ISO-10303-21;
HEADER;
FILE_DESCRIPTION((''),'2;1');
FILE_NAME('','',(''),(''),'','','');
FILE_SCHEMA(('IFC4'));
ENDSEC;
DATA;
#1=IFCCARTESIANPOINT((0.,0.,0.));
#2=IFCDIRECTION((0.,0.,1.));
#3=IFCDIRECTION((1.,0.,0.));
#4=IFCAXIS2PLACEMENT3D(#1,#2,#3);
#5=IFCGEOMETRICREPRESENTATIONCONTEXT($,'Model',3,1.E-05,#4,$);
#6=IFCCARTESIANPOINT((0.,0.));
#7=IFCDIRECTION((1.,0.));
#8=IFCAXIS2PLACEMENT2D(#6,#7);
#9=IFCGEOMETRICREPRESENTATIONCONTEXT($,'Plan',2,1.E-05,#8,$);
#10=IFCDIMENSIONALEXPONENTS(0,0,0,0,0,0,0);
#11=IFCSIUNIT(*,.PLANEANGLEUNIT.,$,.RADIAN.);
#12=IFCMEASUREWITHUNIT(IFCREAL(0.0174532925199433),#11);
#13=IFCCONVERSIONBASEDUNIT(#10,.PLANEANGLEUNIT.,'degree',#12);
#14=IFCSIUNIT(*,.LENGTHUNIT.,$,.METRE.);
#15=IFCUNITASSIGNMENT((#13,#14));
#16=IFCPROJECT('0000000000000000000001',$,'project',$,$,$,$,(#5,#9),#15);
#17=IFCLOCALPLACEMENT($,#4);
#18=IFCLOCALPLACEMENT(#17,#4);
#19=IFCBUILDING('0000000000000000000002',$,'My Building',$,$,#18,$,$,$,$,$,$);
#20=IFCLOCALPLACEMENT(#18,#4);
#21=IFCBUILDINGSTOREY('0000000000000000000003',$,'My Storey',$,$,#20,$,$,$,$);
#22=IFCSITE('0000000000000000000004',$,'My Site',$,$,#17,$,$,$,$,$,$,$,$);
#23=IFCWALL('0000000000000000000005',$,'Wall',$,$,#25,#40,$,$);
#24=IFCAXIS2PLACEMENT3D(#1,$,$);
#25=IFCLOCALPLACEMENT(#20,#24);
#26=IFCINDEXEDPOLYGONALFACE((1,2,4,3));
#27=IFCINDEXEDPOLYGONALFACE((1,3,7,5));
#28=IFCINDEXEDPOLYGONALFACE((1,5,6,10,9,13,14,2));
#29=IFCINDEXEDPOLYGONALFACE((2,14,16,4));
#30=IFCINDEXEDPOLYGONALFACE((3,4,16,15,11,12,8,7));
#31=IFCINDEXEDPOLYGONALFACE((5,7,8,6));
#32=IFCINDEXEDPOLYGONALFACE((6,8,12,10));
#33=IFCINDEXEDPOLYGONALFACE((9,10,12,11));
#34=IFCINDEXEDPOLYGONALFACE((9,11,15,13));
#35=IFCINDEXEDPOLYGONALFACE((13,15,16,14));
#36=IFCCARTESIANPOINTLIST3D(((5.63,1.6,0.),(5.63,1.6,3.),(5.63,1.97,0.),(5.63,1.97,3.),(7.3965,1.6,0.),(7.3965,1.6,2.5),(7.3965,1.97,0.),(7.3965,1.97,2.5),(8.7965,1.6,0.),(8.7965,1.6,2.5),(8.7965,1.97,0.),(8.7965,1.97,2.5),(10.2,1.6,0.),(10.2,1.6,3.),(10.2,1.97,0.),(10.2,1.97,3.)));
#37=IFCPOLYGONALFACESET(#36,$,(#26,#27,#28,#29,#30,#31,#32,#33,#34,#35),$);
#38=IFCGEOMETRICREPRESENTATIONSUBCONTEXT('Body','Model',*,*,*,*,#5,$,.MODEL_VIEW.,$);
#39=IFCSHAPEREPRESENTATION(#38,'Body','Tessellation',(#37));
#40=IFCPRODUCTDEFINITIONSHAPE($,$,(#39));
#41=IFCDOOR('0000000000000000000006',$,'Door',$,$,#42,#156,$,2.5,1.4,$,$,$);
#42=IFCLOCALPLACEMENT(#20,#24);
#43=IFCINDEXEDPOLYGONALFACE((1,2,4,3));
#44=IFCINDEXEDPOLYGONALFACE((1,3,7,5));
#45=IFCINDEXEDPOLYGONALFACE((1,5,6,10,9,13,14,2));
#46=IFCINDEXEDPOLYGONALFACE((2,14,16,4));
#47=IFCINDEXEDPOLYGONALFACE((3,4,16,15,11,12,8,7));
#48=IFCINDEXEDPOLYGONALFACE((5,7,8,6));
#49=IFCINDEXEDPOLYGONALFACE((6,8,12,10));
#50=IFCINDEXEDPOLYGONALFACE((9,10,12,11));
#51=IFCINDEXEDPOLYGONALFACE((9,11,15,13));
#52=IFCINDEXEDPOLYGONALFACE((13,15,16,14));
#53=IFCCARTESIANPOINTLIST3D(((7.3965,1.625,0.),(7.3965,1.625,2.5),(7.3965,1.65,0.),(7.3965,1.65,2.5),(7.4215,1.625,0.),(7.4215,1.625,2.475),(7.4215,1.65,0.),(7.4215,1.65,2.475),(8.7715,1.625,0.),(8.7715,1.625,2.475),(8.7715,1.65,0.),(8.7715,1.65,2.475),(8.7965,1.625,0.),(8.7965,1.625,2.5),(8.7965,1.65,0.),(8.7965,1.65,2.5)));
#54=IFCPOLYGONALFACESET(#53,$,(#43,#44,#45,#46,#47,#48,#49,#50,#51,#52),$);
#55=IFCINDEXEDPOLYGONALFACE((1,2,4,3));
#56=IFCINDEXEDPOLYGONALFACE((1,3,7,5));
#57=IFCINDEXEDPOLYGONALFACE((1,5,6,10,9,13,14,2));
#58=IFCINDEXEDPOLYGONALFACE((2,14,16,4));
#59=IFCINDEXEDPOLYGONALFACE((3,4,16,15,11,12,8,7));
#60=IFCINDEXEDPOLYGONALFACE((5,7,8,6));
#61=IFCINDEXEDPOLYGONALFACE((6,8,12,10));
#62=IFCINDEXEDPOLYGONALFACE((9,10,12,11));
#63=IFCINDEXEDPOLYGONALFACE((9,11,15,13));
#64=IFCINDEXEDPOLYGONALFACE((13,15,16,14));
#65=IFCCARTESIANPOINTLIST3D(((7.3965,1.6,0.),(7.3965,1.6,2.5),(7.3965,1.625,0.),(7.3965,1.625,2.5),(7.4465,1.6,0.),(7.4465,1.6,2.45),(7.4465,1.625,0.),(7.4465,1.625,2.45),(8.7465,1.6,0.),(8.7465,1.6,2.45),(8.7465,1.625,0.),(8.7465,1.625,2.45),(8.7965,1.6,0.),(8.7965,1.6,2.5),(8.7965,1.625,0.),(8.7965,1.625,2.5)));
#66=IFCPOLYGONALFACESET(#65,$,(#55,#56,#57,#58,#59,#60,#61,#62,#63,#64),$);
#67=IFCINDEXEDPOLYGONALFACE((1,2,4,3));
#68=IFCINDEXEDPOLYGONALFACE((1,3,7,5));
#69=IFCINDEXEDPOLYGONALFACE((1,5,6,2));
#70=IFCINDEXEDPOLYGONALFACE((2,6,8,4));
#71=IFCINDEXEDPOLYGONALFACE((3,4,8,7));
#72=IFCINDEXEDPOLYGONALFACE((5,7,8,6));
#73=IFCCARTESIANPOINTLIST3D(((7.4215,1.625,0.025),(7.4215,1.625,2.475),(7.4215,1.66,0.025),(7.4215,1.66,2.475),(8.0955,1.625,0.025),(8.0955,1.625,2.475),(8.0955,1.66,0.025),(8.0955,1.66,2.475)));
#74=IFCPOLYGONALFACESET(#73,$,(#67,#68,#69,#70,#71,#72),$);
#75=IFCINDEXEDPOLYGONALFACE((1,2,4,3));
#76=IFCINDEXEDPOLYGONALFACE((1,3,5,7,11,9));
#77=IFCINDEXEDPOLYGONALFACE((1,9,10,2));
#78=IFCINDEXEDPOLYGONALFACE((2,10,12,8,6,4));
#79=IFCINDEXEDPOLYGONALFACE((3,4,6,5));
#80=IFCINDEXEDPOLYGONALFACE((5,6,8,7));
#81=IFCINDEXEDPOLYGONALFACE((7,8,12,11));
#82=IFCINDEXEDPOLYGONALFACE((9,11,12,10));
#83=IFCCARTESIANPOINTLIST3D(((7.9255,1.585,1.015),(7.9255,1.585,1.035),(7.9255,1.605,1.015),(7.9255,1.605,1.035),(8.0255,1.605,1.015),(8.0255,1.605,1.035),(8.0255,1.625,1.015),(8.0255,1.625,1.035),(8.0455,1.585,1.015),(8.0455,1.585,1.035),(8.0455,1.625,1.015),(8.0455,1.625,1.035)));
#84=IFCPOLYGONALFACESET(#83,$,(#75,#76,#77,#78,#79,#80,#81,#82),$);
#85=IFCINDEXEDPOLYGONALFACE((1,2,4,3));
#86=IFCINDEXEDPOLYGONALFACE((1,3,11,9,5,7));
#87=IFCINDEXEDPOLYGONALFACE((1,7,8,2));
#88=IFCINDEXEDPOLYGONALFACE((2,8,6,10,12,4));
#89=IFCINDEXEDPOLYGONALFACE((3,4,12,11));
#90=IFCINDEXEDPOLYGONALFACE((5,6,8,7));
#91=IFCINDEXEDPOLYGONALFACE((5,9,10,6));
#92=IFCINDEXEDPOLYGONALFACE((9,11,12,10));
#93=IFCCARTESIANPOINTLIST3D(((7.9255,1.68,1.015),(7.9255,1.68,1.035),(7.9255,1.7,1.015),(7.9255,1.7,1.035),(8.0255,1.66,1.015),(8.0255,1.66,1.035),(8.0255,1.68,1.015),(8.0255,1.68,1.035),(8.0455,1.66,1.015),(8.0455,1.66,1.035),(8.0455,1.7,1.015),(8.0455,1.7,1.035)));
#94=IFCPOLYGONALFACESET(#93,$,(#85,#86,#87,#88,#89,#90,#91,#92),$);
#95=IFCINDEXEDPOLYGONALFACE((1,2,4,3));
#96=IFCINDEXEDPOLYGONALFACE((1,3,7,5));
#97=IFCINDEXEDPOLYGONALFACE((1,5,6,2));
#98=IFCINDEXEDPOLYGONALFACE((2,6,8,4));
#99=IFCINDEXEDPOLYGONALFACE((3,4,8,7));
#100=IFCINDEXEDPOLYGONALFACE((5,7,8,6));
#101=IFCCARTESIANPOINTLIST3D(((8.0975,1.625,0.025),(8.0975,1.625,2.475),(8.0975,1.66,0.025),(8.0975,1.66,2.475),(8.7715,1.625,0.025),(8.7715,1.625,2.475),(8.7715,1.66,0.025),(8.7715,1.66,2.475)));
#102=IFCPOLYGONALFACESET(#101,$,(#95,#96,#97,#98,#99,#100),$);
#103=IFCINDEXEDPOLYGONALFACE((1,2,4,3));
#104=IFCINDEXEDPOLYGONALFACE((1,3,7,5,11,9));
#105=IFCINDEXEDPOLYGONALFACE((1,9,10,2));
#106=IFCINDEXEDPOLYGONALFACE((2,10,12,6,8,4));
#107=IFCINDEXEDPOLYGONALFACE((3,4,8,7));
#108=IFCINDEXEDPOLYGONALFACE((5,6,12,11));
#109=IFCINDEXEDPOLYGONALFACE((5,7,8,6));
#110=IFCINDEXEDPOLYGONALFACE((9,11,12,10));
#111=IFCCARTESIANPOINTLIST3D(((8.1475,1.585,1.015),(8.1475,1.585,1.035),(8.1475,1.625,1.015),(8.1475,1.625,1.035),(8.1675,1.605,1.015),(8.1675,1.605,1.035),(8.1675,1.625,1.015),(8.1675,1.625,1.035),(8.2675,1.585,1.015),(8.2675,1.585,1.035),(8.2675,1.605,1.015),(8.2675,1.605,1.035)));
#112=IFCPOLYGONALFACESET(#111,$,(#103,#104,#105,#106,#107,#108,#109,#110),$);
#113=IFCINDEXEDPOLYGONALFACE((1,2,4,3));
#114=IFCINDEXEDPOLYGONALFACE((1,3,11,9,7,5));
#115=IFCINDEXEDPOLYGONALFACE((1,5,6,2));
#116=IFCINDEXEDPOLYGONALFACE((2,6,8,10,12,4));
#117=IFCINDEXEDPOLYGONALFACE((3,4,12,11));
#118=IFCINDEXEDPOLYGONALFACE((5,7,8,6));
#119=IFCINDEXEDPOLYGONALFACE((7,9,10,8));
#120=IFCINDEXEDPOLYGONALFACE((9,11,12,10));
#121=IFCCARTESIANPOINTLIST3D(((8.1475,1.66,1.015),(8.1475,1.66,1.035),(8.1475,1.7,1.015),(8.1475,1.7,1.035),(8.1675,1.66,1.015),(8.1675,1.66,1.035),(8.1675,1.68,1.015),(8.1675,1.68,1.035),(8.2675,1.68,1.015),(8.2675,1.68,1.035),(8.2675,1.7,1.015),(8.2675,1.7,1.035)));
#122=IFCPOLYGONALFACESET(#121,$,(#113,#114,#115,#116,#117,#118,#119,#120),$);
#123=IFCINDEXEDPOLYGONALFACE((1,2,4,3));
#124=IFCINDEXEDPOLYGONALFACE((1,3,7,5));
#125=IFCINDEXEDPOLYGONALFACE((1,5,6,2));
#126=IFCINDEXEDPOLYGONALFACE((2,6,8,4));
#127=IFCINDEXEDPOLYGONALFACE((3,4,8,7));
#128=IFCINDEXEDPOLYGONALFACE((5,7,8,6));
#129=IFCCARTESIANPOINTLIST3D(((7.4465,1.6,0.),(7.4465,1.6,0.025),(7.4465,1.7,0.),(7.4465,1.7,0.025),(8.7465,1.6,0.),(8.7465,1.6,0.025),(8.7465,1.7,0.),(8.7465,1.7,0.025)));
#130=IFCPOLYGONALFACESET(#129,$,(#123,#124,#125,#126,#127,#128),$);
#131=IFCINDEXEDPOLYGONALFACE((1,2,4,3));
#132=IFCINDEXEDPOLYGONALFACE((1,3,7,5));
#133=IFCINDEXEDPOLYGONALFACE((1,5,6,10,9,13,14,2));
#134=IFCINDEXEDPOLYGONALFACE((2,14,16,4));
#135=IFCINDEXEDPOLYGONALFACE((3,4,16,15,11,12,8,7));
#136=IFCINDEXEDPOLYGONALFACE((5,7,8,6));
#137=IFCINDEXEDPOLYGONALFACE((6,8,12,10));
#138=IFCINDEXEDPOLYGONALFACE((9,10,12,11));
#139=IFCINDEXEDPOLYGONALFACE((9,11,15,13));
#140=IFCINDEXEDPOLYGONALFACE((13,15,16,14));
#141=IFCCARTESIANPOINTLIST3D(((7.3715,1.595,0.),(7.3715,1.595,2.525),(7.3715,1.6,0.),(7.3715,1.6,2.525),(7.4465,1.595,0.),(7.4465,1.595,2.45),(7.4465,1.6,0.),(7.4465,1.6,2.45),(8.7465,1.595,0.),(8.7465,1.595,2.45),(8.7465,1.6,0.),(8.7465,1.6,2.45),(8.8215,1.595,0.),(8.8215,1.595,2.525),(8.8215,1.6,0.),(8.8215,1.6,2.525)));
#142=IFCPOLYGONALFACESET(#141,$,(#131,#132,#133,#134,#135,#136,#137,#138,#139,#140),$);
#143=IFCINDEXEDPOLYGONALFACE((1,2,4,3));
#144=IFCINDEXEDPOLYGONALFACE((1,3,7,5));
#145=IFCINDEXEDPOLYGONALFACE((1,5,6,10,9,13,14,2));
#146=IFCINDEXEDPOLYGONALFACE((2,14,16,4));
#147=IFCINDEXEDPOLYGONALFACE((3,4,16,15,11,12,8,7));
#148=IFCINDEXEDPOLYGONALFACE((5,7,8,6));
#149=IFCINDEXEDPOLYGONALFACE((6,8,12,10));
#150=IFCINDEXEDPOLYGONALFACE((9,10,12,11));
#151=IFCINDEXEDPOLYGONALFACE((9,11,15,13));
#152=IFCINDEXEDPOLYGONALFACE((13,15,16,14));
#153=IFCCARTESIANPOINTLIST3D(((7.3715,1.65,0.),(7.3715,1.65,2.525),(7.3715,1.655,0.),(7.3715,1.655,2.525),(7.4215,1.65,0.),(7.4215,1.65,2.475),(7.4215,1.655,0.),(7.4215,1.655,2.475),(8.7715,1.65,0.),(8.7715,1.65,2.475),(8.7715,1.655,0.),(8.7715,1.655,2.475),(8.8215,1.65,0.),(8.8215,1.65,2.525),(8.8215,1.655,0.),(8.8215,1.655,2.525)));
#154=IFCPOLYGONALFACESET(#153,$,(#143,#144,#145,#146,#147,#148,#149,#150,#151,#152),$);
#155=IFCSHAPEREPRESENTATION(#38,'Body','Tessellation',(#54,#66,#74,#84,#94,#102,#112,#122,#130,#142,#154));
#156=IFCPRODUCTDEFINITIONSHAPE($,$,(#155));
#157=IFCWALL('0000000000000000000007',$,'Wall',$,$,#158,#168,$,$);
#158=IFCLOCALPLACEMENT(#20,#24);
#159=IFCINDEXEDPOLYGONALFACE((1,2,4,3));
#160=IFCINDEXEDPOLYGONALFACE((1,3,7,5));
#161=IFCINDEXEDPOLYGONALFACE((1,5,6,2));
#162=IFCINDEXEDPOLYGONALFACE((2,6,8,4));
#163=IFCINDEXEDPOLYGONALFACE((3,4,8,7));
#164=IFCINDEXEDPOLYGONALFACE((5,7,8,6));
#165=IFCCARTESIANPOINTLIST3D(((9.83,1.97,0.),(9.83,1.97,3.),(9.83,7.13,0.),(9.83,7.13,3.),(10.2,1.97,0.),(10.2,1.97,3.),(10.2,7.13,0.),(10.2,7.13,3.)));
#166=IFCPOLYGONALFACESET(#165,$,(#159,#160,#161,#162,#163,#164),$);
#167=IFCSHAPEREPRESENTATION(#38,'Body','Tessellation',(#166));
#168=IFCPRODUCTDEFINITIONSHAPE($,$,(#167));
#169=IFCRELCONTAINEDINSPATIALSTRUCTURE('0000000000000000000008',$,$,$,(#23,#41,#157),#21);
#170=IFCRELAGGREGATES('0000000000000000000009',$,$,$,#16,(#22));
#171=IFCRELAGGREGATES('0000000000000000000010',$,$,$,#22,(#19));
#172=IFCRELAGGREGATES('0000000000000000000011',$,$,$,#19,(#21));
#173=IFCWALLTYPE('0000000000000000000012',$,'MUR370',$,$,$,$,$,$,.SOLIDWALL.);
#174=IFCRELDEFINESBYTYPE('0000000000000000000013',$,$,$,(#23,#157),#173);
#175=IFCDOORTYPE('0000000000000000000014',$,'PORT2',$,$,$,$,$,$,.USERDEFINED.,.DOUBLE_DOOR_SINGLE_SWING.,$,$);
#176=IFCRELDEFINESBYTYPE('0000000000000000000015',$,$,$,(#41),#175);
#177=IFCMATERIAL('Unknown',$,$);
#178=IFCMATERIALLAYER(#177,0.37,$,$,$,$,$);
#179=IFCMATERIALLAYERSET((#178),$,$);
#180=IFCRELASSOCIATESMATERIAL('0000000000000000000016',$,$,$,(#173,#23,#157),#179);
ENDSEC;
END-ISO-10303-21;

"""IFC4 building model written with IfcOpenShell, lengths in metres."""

from ifc_helpers import new_model, entity, si_unit, converted_unit, frame, origin_with_axes, origin_2d_with_axis, place, context, subcontext, project, spatial, line, indexed_curve, outline, extrude, shape, source, transform, mapped, material, layer, layer_set, layer_usage, type_object, type_shapes, element, fill, save


model = new_model("IFC4")

# Units and contexts
model_context = context("Model", 3, precision=1e-05, world=origin_with_axes())
plan_context = context("Plan", 2, precision=1e-05, world=origin_2d_with_axis())
body_context_1 = subcontext(model_context, "Body", "Model", "MODEL_VIEW")
body_context_2 = subcontext(plan_context, "Body", "Plan", "PLAN_VIEW")
ifc_project = project(units=[converted_unit("PLANEANGLEUNIT", "degree", entity("IfcReal", 0.0174532925199433), si_unit("PLANEANGLEUNIT", "RADIAN"), dimensions=[0, 0, 0, 0, 0, 0, 0]), si_unit("LENGTHUNIT", "METRE")], contexts=[model_context, plan_context])

# Site, building, storey
site_placement = place(None, origin_with_axes())
site = spatial("IfcSite", under=ifc_project, at=site_placement, Name="My Site")
building_placement = place(site_placement, origin_with_axes())
building = spatial("IfcBuilding", under=site, at=building_placement, Name="My Building")
storey_placement = place(building_placement, origin_with_axes())
storey = spatial("IfcBuildingStorey", under=building, at=storey_placement, Name="My Storey")

# Shared definitions
ifc_material = material(Name="Unknown")

# Shared definitions
ifc_layer_1 = layer(ifc_material, 0.37)
ifc_layer_set_1 = layer_set([ifc_layer_1])
wall_type_1 = type_object("IfcWallType", Name="MUR370", PredefinedType="SOLIDWALL", material=ifc_layer_set_1)

# Wall, opening, door
ifc_layer_usage_1 = layer_usage(ifc_layer_set_1, "AXIS2", "POSITIVE", 0.0)
wall_1_placement = place(storey_placement, frame((5.63, 1.6, 0.0), z_axis=(0.0, 0.0, 1.0), x_axis=(1.0, -0.000001, 0.0)))
wall_1 = element("IfcWall", 1, at=wall_1_placement, inside=storey, type_object=wall_type_1, material=ifc_layer_usage_1, Name="Wall", context=body_context_1, shape_type="SweptSolid", body=[
    extrude(outline(indexed_curve([(0.0, 0.0), (0.0, 0.37), (4.57, 0.37), (4.57, 0.0), (0.0, 0.0)], self_intersect=False)), origin_with_axes(), (0.0, 0.0, 1.0), 3.0),
])
shared_shape_1 = source(origin_with_axes(), body_context_1, "Body", "SweptSolid", [
    extrude(outline(indexed_curve([(0.0, 0.0), (1.4, 0.0), (1.4, 2.5), (0.0, 2.5)], segments=[line(1, 2, 3, 4, 1)])), frame((0.0, -0.1, 0.0), z_axis=(0.0, -1.0, 0.0), x_axis=(1.0, 0.0, 0.0)), (0.0, 0.0, -1.0), 0.57),
])
opening_1_placement = place(wall_1_placement, frame((1.7665, 0.0, 0.0), z_axis=(0.0, 0.0, 1.0), x_axis=(1.0, 0.0, 0.0)))
opening_1 = element("IfcOpeningElement", 2, at=opening_1_placement, cuts=wall_1, PredefinedType="OPENING", context=body_context_1, shape_type="MappedRepresentation", body=[
    mapped(shared_shape_1, transform((0.0, 0.0, 0.0), x_axis=(1.0, 0.0, 0.0), y_axis=(0.0, 1.0, 0.0), z_axis=(0.0, 0.0, 1.0), scale=1.0)),
])
door_type_1 = type_object("IfcDoorType", Name="PORT2", OperationType="DOUBLE_DOOR_SINGLE_SWING", PredefinedType="USERDEFINED")
shared_shape_2 = source(origin_with_axes(), body_context_1, "Body", "SweptSolid", [
    extrude(outline(indexed_curve([(0.0, 0.0), (0.0, 2.5), (1.4, 2.5), (1.4, 0.0), (1.375, 0.0), (1.375, 2.475), (0.025, 2.475), (0.025, 0.0)], segments=[line(1, 2, 3, 4, 5, 6, 7, 8, 1)])), frame((0.0, 0.025, 0.0), z_axis=(0.0, -1.0, 0.0), x_axis=(1.0, 0.0, 0.0)), (0.0, 0.0, -1.0), 0.025),
    extrude(outline(indexed_curve([(0.0, 0.0), (0.0, 2.5), (1.4, 2.5), (1.4, 0.0), (1.35, 0.0), (1.35, 2.45), (0.05, 2.45), (0.05, 0.0)], segments=[line(1, 2, 3, 4, 5, 6, 7, 8, 1)])), frame((0.0, 0.0, 0.0), z_axis=(0.0, -1.0, 0.0), x_axis=(1.0, 0.0, 0.0)), (0.0, 0.0, -1.0), 0.025),
    extrude(outline(indexed_curve([(0.0, 0.0), (0.674, 0.0), (0.674, 0.035), (0.0, 0.035)], segments=[line(1, 2, 3, 4, 1)])), frame((0.025, 0.025, 0.025), z_axis=(0.0, 0.0, 1.0), x_axis=(1.0, 0.0, 0.0)), (0.0, 0.0, 1.0), 2.45),
    extrude(outline(indexed_curve([(0.0, 0.0), (0.0, -0.04), (-0.12, -0.04), (-0.12, -0.02), (-0.02, -0.02), (-0.02, 0.0)], segments=[line(1, 2, 3, 4, 5, 6, 1)])), frame((0.649, 0.025, 1.015), z_axis=(0.0, 0.0, 1.0), x_axis=(1.0, 0.0, 0.0)), (0.0, 0.0, 1.0), 0.02),
    extrude(outline(indexed_curve([(0.0, 0.0), (0.0, 0.04), (-0.12, 0.04), (-0.12, 0.02), (-0.02, 0.02), (-0.02, 0.0)], segments=[line(1, 2, 3, 4, 5, 6, 1)])), frame((0.649, 0.06, 1.015), z_axis=(0.0, 0.0, 1.0), x_axis=(1.0, 0.0, 0.0)), (0.0, 0.0, 1.0), 0.02),
    extrude(outline(indexed_curve([(0.0, 0.0), (-0.674, 0.0), (-0.674, 0.035), (0.0, 0.035)], segments=[line(1, 2, 3, 4, 1)])), frame((1.375, 0.025, 0.025), z_axis=(0.0, 0.0, 1.0), x_axis=(1.0, 0.0, 0.0)), (0.0, 0.0, 1.0), 2.45),
    extrude(outline(indexed_curve([(0.0, 0.0), (0.0, -0.04), (0.12, -0.04), (0.12, -0.02), (0.02, -0.02), (0.02, 0.0)], segments=[line(1, 2, 3, 4, 5, 6, 1)])), frame((0.751, 0.025, 1.015), z_axis=(0.0, 0.0, 1.0), x_axis=(1.0, 0.0, 0.0)), (0.0, 0.0, 1.0), 0.02),
    extrude(outline(indexed_curve([(0.0, 0.0), (0.0, 0.04), (0.12, 0.04), (0.12, 0.02), (0.02, 0.02), (0.02, 0.0)], segments=[line(1, 2, 3, 4, 5, 6, 1)])), frame((0.751, 0.06, 1.015), z_axis=(0.0, 0.0, 1.0), x_axis=(1.0, 0.0, 0.0)), (0.0, 0.0, 1.0), 0.02),
    extrude(outline(indexed_curve([(0.0, 0.0), (1.3, 0.0), (1.3, 0.1), (0.0, 0.1)], segments=[line(1, 2, 3, 4, 1)])), frame((0.05, 0.0, 0.0), z_axis=(0.0, 0.0, 1.0), x_axis=(1.0, 0.0, 0.0)), (0.0, 0.0, 1.0), 0.025),
    extrude(outline(indexed_curve([(0.0, 0.0), (0.0, 2.525), (1.45, 2.525), (1.45, 0.0), (1.375, 0.0), (1.375, 2.45), (0.075, 2.45), (0.075, 0.0)], segments=[line(1, 2, 3, 4, 5, 6, 7, 8, 1)])), frame((-0.025, -0.005, 0.0), z_axis=(0.0, -1.0, 0.0), x_axis=(1.0, 0.0, 0.0)), (0.0, 0.0, -1.0), 0.005),
    extrude(outline(indexed_curve([(0.0, 0.0), (0.0, 2.525), (1.45, 2.525), (1.45, 0.0), (1.4, 0.0), (1.4, 2.475), (0.05, 2.475), (0.05, 0.0)], segments=[line(1, 2, 3, 4, 5, 6, 7, 8, 1)])), frame((-0.025, 0.05, 0.0), z_axis=(0.0, -1.0, 0.0), x_axis=(1.0, 0.0, 0.0)), (0.0, 0.0, -1.0), 0.005),
])
shared_shape_3 = source(origin_with_axes(), body_context_2, "Body", "Curve2D", [
    entity("IfcIndexedPolyCurve", entity("IfcCartesianPointList2D", [[0.0, 0.0], [0.0, 0.05], [0.025, 0.05], [0.025, 0.025], [0.05, 0.025], [0.05, 0.0]]), [entity("IfcLineIndex", [1, 2, 3, 4, 5, 6, 1])]),
    entity("IfcIndexedPolyCurve", entity("IfcCartesianPointList2D", [[1.4, 0.0], [1.4, 0.05], [1.375, 0.05], [1.375, 0.025], [1.35, 0.025], [1.35, 0.0]]), [entity("IfcLineIndex", [1, 2, 3, 4, 5, 6, 1])]),
    entity("IfcTrimmedCurve", entity("IfcEllipse", entity("IfcAxis2Placement2D", entity("IfcCartesianPoint", [0.06, 0.05]), entity("IfcDirection", [1.0, 0.0])), 0.64, 0.675), [entity("IfcCartesianPoint", [0.7, 0.05])], [entity("IfcCartesianPoint", [0.06, 0.725])], True, "CARTESIAN"),
    entity("IfcIndexedPolyCurve", entity("IfcCartesianPointList2D", [[0.025, 0.05], [0.06, 0.05], [0.06, 0.725], [0.025, 0.725]]), [entity("IfcLineIndex", [1, 2, 3, 4, 1])]),
    entity("IfcTrimmedCurve", entity("IfcEllipse", entity("IfcAxis2Placement2D", entity("IfcCartesianPoint", [1.34, 0.05]), entity("IfcDirection", [1.0, 0.0])), 0.64, 0.675), [entity("IfcCartesianPoint", [1.34, 0.725])], [entity("IfcCartesianPoint", [0.7, 0.05])], True, "CARTESIAN"),
    entity("IfcIndexedPolyCurve", entity("IfcCartesianPointList2D", [[1.375, 0.05], [1.34, 0.05], [1.34, 0.725], [1.375, 0.725]]), [entity("IfcLineIndex", [1, 2, 3, 4, 1])]),
])
type_shapes(door_type_1, [shared_shape_2, shared_shape_3])
door_1_placement = place(opening_1_placement, frame((0.0, 0.0, 0.0), z_axis=(0.0, 0.0, 1.0), x_axis=(1.0, 0.0, 0.0)))
door_1 = element("IfcDoor", 3, at=door_1_placement, inside=storey, type_object=door_type_1, Name="Door", OverallHeight=2.5, OverallWidth=1.4, shapes=[
    shape(body_context_1, "Body", "MappedRepresentation", [mapped(shared_shape_2, transform((0.0, 0.0, 0.0), x_axis=(1.0, 0.0, 0.0), y_axis=(0.0, 1.0, 0.0), z_axis=(0.0, 0.0, 1.0), scale=1.0))]),
    shape(body_context_2, "Body", "MappedRepresentation", [mapped(shared_shape_3, transform((0.0, 0.0, 0.0), x_axis=(1.0, 0.0, 0.0), y_axis=(0.0, 1.0, 0.0), z_axis=(0.0, 0.0, 1.0), scale=1.0))]),
])
fill(opening_1, door_1)

# Wall
ifc_layer_usage_2 = layer_usage(ifc_layer_set_1, "AXIS2", "POSITIVE", 0.0)
wall_2_placement = place(storey_placement, frame((10.2, 1.97, 0.0), z_axis=(0.0, 0.0, 1.0), x_axis=(0.000001, 1.0, 0.0)))
element("IfcWall", 4, at=wall_2_placement, inside=storey, type_object=wall_type_1, material=ifc_layer_usage_2, Name="Wall", context=body_context_1, shape_type="SweptSolid", body=[
    extrude(outline(indexed_curve([(0.0, 0.0), (0.0, 0.37), (5.16, 0.37), (5.16, 0.0), (0.0, 0.0)], self_intersect=False)), origin_with_axes(), (0.0, 0.0, 1.0), 3.0),
])

save(model, "model.ifc")
